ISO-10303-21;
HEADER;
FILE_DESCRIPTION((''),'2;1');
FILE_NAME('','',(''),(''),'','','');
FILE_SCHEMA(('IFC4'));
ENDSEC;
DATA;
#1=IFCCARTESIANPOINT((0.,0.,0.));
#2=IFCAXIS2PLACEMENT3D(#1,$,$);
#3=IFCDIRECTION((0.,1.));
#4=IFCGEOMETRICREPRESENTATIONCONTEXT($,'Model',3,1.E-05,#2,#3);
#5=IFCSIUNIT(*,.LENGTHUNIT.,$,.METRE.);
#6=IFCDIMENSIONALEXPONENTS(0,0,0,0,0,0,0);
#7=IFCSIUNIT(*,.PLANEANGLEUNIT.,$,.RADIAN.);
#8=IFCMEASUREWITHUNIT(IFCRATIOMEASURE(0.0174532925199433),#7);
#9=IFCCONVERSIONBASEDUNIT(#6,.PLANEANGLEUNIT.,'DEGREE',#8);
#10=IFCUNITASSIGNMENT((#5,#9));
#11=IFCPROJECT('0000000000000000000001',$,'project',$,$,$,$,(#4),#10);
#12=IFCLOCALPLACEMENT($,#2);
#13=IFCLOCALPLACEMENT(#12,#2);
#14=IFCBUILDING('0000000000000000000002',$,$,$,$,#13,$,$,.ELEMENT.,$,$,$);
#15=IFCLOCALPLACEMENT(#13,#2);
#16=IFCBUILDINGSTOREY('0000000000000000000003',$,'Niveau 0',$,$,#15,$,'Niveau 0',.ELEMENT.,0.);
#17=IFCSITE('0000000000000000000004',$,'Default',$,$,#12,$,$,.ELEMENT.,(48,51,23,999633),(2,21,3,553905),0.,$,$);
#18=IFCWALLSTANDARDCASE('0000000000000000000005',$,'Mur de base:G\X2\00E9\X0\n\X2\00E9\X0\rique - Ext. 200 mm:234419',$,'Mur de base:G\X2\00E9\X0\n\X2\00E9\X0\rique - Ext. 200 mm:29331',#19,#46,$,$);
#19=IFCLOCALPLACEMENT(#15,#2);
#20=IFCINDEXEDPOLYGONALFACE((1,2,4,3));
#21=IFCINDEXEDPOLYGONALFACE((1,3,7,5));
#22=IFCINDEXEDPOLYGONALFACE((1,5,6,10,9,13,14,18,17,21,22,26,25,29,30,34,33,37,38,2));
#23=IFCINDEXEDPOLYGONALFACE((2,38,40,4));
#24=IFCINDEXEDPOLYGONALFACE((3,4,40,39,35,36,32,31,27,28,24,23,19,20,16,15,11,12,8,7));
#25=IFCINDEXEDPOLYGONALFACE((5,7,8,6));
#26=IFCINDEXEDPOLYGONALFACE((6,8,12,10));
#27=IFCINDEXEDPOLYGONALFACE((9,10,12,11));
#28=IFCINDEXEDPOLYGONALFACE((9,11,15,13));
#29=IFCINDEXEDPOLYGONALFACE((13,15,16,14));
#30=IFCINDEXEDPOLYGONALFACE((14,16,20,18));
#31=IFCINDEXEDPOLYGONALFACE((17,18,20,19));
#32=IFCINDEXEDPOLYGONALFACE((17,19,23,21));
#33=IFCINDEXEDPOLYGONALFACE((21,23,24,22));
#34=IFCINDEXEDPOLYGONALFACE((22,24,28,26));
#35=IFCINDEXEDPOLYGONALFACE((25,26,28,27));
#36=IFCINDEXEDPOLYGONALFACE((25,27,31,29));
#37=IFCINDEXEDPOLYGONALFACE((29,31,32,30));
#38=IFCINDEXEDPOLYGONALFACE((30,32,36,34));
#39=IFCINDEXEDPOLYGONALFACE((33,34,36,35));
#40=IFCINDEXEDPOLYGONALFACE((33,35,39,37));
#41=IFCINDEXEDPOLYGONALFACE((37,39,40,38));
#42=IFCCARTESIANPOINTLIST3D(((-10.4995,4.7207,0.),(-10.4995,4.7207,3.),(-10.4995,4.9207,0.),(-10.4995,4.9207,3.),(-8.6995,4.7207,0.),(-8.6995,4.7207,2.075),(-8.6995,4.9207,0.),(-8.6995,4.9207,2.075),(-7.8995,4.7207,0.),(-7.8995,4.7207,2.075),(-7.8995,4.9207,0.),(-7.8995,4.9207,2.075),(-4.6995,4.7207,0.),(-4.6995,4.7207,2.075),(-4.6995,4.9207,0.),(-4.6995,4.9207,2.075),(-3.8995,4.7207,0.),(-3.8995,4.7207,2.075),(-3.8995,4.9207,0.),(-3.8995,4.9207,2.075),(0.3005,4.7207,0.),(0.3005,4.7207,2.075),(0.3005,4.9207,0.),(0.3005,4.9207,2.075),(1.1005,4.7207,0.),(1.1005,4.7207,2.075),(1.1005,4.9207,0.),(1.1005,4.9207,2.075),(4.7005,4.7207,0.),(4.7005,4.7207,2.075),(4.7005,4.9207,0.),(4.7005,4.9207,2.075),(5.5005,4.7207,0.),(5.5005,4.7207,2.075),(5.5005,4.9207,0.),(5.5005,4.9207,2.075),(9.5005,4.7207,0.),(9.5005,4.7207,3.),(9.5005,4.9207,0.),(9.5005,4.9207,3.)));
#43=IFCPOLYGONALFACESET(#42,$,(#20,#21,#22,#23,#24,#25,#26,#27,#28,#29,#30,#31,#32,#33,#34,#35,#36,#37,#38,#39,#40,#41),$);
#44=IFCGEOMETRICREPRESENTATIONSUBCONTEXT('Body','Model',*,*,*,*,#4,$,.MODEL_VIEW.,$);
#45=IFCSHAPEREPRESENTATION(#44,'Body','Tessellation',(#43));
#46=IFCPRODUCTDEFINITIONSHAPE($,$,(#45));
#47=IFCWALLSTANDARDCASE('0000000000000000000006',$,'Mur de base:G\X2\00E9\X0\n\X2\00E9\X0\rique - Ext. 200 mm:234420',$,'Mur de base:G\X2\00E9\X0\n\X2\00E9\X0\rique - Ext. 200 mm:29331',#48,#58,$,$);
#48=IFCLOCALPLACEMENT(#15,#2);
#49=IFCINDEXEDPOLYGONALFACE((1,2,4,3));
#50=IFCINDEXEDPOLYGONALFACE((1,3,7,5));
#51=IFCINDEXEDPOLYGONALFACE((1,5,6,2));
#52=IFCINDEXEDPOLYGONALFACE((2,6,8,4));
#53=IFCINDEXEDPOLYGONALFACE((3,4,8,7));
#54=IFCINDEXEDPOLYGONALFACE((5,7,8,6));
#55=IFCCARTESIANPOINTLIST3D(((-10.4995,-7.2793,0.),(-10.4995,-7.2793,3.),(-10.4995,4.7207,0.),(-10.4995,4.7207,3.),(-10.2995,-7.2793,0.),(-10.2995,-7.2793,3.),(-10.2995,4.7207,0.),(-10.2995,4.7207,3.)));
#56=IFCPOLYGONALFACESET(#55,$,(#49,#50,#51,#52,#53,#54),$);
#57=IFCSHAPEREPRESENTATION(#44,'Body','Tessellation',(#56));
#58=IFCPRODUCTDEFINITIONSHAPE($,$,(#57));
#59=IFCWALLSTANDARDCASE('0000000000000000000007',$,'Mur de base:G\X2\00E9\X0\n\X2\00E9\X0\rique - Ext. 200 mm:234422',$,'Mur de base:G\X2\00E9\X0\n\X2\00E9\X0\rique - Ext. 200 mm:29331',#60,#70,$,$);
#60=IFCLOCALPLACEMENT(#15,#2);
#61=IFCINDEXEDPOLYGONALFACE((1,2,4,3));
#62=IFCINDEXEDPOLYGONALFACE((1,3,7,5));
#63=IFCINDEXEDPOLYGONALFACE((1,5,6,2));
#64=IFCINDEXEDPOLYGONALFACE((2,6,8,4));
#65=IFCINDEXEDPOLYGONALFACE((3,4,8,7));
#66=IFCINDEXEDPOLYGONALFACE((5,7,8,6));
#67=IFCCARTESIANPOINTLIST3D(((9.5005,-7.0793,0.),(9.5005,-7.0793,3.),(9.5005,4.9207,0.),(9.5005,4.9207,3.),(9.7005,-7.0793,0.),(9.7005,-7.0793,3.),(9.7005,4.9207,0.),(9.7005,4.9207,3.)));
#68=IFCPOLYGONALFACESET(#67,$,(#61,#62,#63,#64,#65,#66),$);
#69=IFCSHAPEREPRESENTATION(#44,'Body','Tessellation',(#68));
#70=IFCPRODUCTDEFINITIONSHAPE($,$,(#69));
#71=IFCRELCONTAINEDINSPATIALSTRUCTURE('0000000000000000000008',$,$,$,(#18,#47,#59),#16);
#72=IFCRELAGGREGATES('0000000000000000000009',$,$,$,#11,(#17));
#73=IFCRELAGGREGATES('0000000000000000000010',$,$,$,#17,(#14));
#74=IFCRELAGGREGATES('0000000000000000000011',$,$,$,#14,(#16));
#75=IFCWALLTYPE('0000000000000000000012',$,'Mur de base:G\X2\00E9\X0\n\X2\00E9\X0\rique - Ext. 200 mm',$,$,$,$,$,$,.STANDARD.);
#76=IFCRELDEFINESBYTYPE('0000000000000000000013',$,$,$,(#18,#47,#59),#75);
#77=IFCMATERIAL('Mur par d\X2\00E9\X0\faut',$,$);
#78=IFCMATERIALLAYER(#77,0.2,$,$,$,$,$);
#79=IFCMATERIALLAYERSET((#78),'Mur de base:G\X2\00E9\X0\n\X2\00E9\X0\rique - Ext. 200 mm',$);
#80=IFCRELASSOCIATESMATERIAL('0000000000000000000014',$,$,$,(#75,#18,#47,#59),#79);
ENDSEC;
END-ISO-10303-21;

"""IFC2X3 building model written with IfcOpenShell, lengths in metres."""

from ifc_helpers import new_model, entity, si_unit, converted_unit, direction, frame, frame_2d, origin, place, context, subcontext, project, spatial, rectangle, extrude, material, layer, layer_set, layer_usage, type_object, element, save


model = new_model("IFC2X3")

# Units and contexts
model_context = context("Model", 3, precision=1e-05, world=origin(), true_north=direction((0.0, 1.0)))
body_context = subcontext(model_context, "Body", "Model", "MODEL_VIEW")
ifc_project = project(units=[si_unit("LENGTHUNIT", "METRE"), converted_unit("PLANEANGLEUNIT", "DEGREE", entity("IfcRatioMeasure", 0.0174532925199433), si_unit("PLANEANGLEUNIT", "RADIAN"), dimensions=[0, 0, 0, 0, 0, 0, 0])], contexts=[model_context])

# Site, building, storey
site_placement = place(None, origin())
site = spatial("IfcSite", under=ifc_project, at=site_placement, Name="Default", CompositionType="ELEMENT", RefLatitude=(48, 51, 23, 999633), RefLongitude=(2, 21, 3, 553905), RefElevation=0.0)
building_placement = place(site_placement, origin())
building = spatial("IfcBuilding", under=site, at=building_placement, CompositionType="ELEMENT")
storey_placement = place(building_placement, origin())
storey = spatial("IfcBuildingStorey", under=building, at=storey_placement, Name="Niveau 0", LongName="Niveau 0", CompositionType="ELEMENT", Elevation=0.0)

# Wall, openings
ifc_material = material(Name="Mur par défaut")
ifc_layer = layer(ifc_material, 0.2)
ifc_layer_set = layer_set([ifc_layer], Name="Mur de base:Générique - Ext. 200 mm")
ifc_layer_usage_1 = layer_usage(ifc_layer_set, "AXIS2", "NEGATIVE", 0.1)
wall_type = type_object("IfcWallType", Name="Mur de base:Générique - Ext. 200 mm", PredefinedType="STANDARD", material=ifc_layer_set)
wall_1_placement = place(storey_placement, frame((-10.4995, 4.8207, 0.0)))
wall_1 = element("IfcWallStandardCase", 1, at=wall_1_placement, inside=storey, type_object=wall_type, material=ifc_layer_usage_1, Name="Mur de base:Générique - Ext. 200 mm:234419", ObjectType="Mur de base:Générique - Ext. 200 mm:29331", context=body_context, shape_type="SweptSolid", body=[
    extrude(rectangle(XDim=20.0, YDim=0.2, at=frame_2d((10.0, 0.0), x_axis=(-1.0, 0.0))), origin(), (0.0, 0.0, 1.0), 3.0),
])
opening_1_placement = place(wall_1_placement, frame((2.6, 0.1, 0.0)))
element("IfcOpeningElement", 2, at=opening_1_placement, cuts=wall_1, ObjectType="Opening", context=body_context, shape_type="SweptSolid", body=[
    extrude(rectangle(XDim=2.075, YDim=0.8, at=frame_2d((1.0375, 0.4), x_axis=(1.0, 0.0))), frame((0.0, 0.0, 0.0), z_axis=(0.0, -1.0, 0.0), x_axis=(0.0, 0.0, 1.0)), (0.0, 0.0, 1.0), 0.2),
])
opening_2_placement = place(wall_1_placement, frame((6.6, 0.1, 0.0)))
element("IfcOpeningElement", 3, at=opening_2_placement, cuts=wall_1, ObjectType="Opening", context=body_context, shape_type="SweptSolid", body=[
    extrude(rectangle(XDim=2.075, YDim=0.8, at=frame_2d((1.0375, 0.4), x_axis=(1.0, 0.0))), frame((0.0, 0.0, 0.0), z_axis=(0.0, -1.0, 0.0), x_axis=(0.0, 0.0, 1.0)), (0.0, 0.0, 1.0), 0.2),
])
opening_3_placement = place(wall_1_placement, frame((10.8, -0.1, 0.0)))
element("IfcOpeningElement", 4, at=opening_3_placement, cuts=wall_1, ObjectType="Opening", context=body_context, shape_type="SweptSolid", body=[
    extrude(rectangle(XDim=2.075, YDim=0.8, at=frame_2d((1.0375, 0.4), x_axis=(1.0, 0.0))), frame((0.0, 0.0, 0.0), z_axis=(0.0, 1.0, 0.0), x_axis=(0.0, 0.0, 1.0)), (0.0, 0.0, 1.0), 0.2),
])
opening_4_placement = place(wall_1_placement, frame((15.2, -0.1, 0.0)))
element("IfcOpeningElement", 5, at=opening_4_placement, cuts=wall_1, ObjectType="Opening", context=body_context, shape_type="SweptSolid", body=[
    extrude(rectangle(XDim=2.075, YDim=0.8, at=frame_2d((1.0375, 0.4), x_axis=(1.0, 0.0))), frame((0.0, 0.0, 0.0), z_axis=(0.0, 1.0, 0.0), x_axis=(0.0, 0.0, 1.0)), (0.0, 0.0, 1.0), 0.2),
])

# Walls
ifc_layer_usage_2 = layer_usage(ifc_layer_set, "AXIS2", "NEGATIVE", 0.1)
wall_2_placement = place(storey_placement, frame((-10.3995, -7.2793, 0.0), z_axis=(0.0, 0.0, 1.0), x_axis=(0.0, 1.0, 0.0)))
element("IfcWallStandardCase", 6, at=wall_2_placement, inside=storey, type_object=wall_type, material=ifc_layer_usage_2, Name="Mur de base:Générique - Ext. 200 mm:234420", ObjectType="Mur de base:Générique - Ext. 200 mm:29331", context=body_context, shape_type="SweptSolid", body=[
    extrude(rectangle(XDim=12.0, YDim=0.2, at=frame_2d((6.0, 0.0), x_axis=(-1.0, 0.0))), origin(), (0.0, 0.0, 1.0), 3.0),
])
ifc_layer_usage_3 = layer_usage(ifc_layer_set, "AXIS2", "NEGATIVE", 0.1)
wall_3_placement = place(storey_placement, frame((9.6005, 4.9207, 0.0), z_axis=(0.0, 0.0, 1.0), x_axis=(0.0, -1.0, 0.0)))
element("IfcWallStandardCase", 7, at=wall_3_placement, inside=storey, type_object=wall_type, material=ifc_layer_usage_3, Name="Mur de base:Générique - Ext. 200 mm:234422", ObjectType="Mur de base:Générique - Ext. 200 mm:29331", context=body_context, shape_type="SweptSolid", body=[
    extrude(rectangle(XDim=12.0, YDim=0.2, at=frame_2d((6.0, 0.0), x_axis=(-1.0, 0.0))), origin(), (0.0, 0.0, 1.0), 3.0),
])

save(model, "model.ifc")
